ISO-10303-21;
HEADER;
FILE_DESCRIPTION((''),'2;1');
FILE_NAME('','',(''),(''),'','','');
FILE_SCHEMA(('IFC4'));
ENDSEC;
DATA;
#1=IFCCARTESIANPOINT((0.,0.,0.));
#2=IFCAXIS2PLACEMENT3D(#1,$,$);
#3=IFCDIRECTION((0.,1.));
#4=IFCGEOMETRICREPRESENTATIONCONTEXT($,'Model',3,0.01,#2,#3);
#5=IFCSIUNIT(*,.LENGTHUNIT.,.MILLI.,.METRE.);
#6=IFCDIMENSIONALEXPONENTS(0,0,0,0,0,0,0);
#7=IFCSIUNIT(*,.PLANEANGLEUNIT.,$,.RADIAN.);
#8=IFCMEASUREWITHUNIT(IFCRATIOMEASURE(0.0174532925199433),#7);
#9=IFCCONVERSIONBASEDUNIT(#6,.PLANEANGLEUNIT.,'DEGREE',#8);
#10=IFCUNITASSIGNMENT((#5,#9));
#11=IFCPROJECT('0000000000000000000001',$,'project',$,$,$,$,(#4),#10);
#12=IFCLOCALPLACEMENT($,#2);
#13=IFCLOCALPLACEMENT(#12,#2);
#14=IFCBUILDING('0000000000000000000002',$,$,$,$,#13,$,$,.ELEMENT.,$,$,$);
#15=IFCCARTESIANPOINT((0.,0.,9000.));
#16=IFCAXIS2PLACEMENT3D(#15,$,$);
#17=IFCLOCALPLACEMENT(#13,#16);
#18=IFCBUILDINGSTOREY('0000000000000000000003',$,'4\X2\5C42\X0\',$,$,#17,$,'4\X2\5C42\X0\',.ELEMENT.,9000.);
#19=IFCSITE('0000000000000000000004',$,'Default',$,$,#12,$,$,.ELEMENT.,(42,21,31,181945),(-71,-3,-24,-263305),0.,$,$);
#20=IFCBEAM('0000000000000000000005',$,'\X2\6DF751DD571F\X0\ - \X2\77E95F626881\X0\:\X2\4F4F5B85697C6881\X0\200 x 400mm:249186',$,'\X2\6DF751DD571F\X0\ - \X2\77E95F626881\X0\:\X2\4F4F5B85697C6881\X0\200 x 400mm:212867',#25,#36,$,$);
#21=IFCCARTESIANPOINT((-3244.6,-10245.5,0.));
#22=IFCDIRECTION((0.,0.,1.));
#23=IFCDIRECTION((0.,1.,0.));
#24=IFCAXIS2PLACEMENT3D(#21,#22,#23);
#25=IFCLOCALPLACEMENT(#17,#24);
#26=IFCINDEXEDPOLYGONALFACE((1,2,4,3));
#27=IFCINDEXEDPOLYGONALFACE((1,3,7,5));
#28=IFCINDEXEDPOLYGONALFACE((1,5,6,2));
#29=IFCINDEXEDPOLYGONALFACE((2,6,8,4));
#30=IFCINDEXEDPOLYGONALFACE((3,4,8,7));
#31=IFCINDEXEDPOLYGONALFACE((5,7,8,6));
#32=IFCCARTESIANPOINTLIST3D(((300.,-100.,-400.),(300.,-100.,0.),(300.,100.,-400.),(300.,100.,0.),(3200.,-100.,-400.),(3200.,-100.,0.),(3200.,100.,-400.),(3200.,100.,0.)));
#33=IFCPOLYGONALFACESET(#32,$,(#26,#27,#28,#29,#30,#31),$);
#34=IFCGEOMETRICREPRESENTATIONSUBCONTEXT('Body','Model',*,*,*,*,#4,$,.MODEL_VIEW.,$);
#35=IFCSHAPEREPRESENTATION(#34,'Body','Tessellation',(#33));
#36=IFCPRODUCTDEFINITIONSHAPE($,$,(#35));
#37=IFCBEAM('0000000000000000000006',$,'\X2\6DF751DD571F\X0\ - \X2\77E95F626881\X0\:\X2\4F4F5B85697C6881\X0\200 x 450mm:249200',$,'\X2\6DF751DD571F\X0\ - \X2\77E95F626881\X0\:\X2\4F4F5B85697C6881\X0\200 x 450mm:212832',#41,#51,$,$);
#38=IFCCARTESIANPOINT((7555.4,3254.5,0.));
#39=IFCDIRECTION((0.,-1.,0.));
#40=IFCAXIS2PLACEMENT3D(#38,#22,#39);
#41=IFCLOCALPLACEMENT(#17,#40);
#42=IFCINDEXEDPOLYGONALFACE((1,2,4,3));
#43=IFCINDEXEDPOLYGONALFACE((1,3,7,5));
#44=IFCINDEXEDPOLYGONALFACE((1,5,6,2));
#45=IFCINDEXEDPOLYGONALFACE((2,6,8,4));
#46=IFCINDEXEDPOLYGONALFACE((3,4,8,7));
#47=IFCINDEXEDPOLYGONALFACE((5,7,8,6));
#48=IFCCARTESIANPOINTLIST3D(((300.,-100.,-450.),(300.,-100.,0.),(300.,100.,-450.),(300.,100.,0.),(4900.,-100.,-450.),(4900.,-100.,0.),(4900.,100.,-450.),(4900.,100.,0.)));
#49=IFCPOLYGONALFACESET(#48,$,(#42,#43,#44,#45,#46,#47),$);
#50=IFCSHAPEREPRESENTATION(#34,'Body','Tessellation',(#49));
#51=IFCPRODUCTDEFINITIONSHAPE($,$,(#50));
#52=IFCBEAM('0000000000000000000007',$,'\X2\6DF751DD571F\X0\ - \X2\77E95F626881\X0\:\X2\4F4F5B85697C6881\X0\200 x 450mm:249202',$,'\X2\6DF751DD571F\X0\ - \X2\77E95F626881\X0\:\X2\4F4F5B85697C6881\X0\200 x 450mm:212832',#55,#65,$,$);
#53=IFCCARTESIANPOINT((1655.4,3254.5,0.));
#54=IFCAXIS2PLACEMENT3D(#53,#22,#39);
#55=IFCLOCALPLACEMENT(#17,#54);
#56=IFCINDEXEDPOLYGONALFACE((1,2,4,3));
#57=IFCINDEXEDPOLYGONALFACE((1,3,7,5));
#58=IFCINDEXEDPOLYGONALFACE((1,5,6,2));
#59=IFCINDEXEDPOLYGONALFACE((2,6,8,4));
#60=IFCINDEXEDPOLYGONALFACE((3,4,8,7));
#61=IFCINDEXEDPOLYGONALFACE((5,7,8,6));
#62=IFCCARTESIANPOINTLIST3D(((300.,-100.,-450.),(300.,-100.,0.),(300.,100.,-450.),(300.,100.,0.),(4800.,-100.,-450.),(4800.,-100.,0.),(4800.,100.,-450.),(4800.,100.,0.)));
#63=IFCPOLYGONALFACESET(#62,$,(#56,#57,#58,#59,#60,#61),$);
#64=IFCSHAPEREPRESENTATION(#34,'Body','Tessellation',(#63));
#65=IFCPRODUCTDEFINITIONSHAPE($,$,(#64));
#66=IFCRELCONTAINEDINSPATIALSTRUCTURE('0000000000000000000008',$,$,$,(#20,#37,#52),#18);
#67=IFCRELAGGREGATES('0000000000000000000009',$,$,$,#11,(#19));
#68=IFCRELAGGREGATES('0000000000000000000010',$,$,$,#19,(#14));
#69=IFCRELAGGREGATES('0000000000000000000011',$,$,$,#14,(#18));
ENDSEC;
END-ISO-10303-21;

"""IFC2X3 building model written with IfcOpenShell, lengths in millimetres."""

from ifc_helpers import new_model, entity, si_unit, converted_unit, direction, frame, frame_2d, origin, origin_2d_with_axis, place, context, subcontext, project, spatial, rectangle, extrude, element, save


model = new_model("IFC2X3")

# Units and contexts
model_context = context("Model", 3, precision=0.01, world=origin(), true_north=direction((0.0, 1.0)))
body_context = subcontext(model_context, "Body", "Model", "MODEL_VIEW")
ifc_project = project(units=[si_unit("LENGTHUNIT", "METRE", prefix="MILLI"), converted_unit("PLANEANGLEUNIT", "DEGREE", entity("IfcRatioMeasure", 0.0174532925199433), si_unit("PLANEANGLEUNIT", "RADIAN"), dimensions=[0, 0, 0, 0, 0, 0, 0])], contexts=[model_context])

# Site, building, storey
site_placement = place(None, origin())
site = spatial("IfcSite", under=ifc_project, at=site_placement, Name="Default", CompositionType="ELEMENT", RefLatitude=(42, 21, 31, 181945), RefLongitude=(-71, -3, -24, -263305), RefElevation=0.0)
building_placement = place(site_placement, origin())
building = spatial("IfcBuilding", under=site, at=building_placement, CompositionType="ELEMENT")
storey_placement = place(building_placement, frame((0.0, 0.0, 9000.0)))
storey = spatial("IfcBuildingStorey", under=building, at=storey_placement, Name="4层", LongName="4层", CompositionType="ELEMENT", Elevation=9000.0)

# Beams
beam_1_placement = place(storey_placement, frame((-3244.6, -10245.5, 0.0), z_axis=(0.0, 0.0, 1.0), x_axis=(0.0, 1.0, 0.0)))
element("IfcBeam", 1, at=beam_1_placement, inside=storey, Name="混凝土 - 矩形梁:住宅楼梁200 x 400mm:249186", ObjectType="混凝土 - 矩形梁:住宅楼梁200 x 400mm:212867", context=body_context, shape_type="SweptSolid", body=[
    extrude(rectangle(XDim=400.0, YDim=200.0, at=origin_2d_with_axis()), frame((300.0, 0.0, -200.0), z_axis=(1.0, 0.0, 0.0), x_axis=(0.0, 0.0, -1.0)), (0.0, 0.0, 1.0), 2900.0),
])
beam_2_placement = place(storey_placement, frame((7555.4, 3254.5, 0.0), z_axis=(0.0, 0.0, 1.0), x_axis=(0.0, -1.0, 0.0)))
element("IfcBeam", 2, at=beam_2_placement, inside=storey, Name="混凝土 - 矩形梁:住宅楼梁200 x 450mm:249200", ObjectType="混凝土 - 矩形梁:住宅楼梁200 x 450mm:212832", context=body_context, shape_type="SweptSolid", body=[
    extrude(rectangle(XDim=450.0, YDim=200.0, at=origin_2d_with_axis()), frame((300.0, 0.0, -225.0), z_axis=(1.0, 0.0, 0.0), x_axis=(0.0, 0.0, -1.0)), (0.0, 0.0, 1.0), 4600.0),
])
beam_3_placement = place(storey_placement, frame((1655.4, 3254.5, 0.0), z_axis=(0.0, 0.0, 1.0), x_axis=(0.0, -1.0, 0.0)))
element("IfcBeam", 3, at=beam_3_placement, inside=storey, Name="混凝土 - 矩形梁:住宅楼梁200 x 450mm:249202", ObjectType="混凝土 - 矩形梁:住宅楼梁200 x 450mm:212832", context=body_context, shape_type="SweptSolid", body=[
    extrude(rectangle(XDim=450.0, YDim=200.0, at=frame_2d((0.0, 0.0), x_axis=(1.0, 0.0))), frame((300.0, 0.0, -225.0), z_axis=(1.0, 0.0, 0.0), x_axis=(0.0, 0.0, -1.0)), (0.0, 0.0, 1.0), 4500.0),
])

save(model, "model.ifc")
